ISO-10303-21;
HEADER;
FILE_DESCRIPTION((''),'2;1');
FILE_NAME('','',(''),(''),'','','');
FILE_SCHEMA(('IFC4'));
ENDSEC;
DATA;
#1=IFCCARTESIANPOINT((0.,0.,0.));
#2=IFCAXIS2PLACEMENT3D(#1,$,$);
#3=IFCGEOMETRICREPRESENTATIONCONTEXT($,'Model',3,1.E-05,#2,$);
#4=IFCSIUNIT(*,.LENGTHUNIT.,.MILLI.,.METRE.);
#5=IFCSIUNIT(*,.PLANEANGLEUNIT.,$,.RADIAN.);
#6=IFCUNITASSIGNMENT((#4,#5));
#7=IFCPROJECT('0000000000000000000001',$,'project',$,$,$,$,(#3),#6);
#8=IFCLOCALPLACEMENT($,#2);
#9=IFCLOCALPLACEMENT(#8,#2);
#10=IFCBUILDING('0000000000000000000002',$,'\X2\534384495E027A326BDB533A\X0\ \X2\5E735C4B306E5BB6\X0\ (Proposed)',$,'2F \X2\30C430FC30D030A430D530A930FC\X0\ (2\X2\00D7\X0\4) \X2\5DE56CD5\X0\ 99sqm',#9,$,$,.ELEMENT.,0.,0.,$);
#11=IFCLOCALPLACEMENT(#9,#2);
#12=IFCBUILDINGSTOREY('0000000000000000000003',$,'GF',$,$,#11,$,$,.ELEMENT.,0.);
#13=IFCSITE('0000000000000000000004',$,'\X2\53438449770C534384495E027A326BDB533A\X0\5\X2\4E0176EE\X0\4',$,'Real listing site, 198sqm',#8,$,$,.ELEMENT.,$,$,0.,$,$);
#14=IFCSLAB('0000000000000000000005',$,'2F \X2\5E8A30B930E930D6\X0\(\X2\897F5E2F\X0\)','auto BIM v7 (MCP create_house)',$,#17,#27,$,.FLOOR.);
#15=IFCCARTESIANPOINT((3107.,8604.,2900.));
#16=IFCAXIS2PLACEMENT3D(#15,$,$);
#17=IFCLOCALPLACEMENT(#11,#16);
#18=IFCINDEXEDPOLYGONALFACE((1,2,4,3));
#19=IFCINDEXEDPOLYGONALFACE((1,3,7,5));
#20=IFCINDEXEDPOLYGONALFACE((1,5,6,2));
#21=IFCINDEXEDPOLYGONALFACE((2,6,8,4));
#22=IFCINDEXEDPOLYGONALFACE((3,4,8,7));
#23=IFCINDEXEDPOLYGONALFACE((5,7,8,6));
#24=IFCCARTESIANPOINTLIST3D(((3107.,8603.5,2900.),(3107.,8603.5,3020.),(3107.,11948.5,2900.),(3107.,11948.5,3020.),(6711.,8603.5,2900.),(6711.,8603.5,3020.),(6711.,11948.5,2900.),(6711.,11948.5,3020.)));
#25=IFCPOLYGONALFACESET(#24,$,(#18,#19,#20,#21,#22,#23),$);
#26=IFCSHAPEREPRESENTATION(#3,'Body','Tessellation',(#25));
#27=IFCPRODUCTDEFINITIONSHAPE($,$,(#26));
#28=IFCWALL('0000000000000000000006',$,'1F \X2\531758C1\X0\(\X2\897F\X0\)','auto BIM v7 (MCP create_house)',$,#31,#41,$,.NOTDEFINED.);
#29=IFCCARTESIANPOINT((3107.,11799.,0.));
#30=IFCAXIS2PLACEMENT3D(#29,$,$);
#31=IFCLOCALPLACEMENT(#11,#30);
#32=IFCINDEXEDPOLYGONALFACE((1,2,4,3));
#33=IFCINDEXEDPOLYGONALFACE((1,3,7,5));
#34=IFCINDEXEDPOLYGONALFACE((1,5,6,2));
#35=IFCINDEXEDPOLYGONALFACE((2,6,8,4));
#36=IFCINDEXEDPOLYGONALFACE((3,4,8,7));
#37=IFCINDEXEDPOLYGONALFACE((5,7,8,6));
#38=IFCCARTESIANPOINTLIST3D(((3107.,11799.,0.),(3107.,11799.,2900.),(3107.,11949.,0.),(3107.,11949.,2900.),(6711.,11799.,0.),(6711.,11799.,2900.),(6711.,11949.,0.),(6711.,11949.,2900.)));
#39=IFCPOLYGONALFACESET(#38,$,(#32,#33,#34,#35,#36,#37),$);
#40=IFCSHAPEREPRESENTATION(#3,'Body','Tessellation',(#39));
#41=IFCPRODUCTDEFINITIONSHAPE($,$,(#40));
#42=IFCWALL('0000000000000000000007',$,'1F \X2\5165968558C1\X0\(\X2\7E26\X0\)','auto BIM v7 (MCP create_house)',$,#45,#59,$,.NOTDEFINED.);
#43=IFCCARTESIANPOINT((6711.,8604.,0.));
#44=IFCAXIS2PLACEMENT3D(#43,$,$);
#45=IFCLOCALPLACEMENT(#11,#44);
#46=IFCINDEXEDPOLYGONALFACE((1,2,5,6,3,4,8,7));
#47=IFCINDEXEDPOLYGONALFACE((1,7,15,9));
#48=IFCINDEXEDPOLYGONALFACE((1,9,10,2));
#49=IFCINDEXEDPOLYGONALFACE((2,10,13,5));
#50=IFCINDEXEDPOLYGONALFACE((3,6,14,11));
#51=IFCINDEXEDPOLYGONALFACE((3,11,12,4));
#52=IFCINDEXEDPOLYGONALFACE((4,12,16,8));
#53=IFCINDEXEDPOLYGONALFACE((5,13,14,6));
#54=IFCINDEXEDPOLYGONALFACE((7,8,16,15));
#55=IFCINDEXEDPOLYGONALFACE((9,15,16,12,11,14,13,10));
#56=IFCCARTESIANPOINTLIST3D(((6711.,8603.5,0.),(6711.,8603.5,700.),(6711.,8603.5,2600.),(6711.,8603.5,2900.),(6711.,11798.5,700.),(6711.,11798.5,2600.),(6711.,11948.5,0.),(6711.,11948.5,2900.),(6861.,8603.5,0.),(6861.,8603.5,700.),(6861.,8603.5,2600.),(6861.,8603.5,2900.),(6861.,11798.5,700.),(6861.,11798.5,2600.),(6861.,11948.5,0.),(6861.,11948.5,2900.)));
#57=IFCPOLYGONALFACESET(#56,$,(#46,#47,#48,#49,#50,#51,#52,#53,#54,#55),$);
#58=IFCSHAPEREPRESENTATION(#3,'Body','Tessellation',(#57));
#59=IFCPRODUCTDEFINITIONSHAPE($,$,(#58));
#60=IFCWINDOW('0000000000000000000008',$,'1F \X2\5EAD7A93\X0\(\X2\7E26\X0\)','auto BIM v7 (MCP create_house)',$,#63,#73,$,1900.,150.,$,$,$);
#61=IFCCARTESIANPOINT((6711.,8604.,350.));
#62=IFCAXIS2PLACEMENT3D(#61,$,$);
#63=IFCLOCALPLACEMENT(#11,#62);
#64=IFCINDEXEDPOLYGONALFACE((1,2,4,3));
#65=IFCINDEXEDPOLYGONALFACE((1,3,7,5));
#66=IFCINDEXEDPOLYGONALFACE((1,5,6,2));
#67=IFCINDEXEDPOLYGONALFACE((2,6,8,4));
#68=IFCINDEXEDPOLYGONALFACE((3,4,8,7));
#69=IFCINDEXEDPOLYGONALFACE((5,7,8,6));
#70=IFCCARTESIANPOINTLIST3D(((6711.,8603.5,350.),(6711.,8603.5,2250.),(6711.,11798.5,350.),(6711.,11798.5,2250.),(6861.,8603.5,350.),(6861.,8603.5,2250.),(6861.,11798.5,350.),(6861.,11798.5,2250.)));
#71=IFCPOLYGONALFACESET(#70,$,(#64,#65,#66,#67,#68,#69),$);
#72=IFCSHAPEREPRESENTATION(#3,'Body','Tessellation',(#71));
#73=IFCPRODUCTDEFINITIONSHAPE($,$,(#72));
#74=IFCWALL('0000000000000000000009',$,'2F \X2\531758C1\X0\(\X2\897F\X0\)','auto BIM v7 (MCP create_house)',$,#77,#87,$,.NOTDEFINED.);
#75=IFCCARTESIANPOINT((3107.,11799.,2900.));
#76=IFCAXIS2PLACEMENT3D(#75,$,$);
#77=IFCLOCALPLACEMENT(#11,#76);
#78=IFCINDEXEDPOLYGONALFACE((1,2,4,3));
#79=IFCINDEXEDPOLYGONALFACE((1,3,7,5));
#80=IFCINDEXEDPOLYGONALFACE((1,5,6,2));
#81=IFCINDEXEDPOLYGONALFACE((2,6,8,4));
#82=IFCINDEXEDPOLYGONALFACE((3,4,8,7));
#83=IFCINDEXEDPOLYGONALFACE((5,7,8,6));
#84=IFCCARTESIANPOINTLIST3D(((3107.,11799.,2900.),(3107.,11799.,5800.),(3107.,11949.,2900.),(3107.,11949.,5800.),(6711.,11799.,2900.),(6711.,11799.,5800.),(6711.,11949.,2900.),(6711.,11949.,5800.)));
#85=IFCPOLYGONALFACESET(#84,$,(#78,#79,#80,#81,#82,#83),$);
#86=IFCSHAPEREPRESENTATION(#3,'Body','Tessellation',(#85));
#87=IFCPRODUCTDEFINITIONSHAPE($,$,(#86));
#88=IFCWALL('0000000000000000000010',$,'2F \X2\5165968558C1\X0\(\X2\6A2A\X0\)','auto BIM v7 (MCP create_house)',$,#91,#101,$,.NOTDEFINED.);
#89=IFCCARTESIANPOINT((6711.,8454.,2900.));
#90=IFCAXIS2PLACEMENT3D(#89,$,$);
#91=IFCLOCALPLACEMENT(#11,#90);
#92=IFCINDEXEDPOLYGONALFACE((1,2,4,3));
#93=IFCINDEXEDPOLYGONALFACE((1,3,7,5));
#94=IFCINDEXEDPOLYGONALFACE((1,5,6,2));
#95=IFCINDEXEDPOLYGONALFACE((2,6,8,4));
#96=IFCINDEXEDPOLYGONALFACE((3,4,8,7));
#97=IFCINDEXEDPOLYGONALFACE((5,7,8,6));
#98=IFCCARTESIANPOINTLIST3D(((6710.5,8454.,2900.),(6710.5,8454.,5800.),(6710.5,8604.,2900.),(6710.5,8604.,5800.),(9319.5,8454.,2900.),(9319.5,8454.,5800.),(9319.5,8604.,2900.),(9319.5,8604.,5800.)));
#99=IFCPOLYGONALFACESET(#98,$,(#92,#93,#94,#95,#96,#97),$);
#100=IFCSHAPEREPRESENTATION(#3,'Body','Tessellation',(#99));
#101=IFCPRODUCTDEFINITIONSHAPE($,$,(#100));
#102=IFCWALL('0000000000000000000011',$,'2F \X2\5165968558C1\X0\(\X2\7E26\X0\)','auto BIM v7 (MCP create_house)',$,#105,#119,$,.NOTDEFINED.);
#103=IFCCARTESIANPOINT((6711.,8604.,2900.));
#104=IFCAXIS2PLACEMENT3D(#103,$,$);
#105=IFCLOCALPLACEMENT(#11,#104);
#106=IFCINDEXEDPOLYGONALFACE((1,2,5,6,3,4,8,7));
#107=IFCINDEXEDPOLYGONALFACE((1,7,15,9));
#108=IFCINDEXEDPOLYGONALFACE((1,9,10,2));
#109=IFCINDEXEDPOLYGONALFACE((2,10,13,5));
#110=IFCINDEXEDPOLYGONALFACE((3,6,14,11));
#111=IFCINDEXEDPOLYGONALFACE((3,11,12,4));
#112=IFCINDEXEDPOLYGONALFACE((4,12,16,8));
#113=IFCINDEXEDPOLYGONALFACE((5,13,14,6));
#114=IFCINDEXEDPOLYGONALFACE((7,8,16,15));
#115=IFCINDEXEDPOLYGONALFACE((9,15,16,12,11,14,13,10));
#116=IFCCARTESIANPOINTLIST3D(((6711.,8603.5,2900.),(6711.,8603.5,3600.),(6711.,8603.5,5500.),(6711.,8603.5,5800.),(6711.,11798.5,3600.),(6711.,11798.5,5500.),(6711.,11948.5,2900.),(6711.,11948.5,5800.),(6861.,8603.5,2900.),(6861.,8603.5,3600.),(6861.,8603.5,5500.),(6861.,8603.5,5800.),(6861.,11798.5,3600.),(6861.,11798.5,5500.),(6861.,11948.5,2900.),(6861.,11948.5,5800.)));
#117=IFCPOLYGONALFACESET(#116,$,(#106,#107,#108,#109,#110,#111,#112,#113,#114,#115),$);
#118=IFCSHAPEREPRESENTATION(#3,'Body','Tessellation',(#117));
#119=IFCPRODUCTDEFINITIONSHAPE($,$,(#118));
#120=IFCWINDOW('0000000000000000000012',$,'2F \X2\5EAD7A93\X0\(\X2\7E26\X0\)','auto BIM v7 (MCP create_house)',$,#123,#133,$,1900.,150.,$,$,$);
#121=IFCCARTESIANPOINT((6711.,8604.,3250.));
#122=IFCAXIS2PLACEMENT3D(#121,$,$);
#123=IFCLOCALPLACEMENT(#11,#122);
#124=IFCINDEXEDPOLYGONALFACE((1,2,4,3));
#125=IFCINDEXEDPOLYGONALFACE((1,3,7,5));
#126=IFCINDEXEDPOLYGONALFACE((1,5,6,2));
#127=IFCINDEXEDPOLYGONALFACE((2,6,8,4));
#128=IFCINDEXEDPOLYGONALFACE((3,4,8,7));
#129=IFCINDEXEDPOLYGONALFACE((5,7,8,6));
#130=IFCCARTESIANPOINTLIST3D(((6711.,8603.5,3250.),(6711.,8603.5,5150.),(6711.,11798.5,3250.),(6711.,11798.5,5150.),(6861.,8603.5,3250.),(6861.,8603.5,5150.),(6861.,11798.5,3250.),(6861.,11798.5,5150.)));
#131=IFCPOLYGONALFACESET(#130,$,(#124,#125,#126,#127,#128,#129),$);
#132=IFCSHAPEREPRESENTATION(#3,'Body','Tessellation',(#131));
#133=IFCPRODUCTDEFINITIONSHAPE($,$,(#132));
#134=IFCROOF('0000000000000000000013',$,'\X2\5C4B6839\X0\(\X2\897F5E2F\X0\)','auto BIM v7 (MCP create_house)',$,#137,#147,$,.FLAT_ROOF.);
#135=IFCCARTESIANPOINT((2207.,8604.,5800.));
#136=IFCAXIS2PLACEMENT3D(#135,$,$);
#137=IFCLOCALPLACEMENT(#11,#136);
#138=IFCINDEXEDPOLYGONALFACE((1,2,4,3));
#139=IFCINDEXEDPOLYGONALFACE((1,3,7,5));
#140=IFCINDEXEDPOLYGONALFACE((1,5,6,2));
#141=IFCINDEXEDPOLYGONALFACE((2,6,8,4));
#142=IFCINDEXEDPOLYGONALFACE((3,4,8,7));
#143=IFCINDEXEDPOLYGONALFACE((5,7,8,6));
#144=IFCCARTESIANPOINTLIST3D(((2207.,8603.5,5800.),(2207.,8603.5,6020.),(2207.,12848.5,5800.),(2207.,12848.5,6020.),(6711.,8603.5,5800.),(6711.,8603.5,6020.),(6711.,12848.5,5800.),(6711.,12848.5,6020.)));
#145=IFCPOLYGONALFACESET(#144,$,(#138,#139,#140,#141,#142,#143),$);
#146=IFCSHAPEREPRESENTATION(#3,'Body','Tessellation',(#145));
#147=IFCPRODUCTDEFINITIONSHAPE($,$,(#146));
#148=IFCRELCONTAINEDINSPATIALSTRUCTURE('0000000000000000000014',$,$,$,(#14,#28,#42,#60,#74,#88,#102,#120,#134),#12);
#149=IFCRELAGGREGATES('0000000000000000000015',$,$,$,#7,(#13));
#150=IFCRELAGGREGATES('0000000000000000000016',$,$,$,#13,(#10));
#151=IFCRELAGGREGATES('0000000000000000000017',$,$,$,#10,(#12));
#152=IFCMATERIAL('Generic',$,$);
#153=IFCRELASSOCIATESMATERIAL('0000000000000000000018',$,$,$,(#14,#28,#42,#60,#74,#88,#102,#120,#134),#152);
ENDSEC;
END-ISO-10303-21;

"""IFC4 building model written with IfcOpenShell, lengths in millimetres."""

from ifc_helpers import new_model, si_unit, frame, frame_2d, origin, place, context, project, spatial, rectangle, extrude, material, element, fill, save


model = new_model("IFC4")

# Units and contexts
model_context = context("Model", 3, precision=1e-05, world=origin())
ifc_project = project(units=[si_unit("LENGTHUNIT", "METRE", prefix="MILLI"), si_unit("PLANEANGLEUNIT", "RADIAN")], contexts=[model_context])

# Site, building, storey
site_placement = place(None, origin())
site = spatial("IfcSite", under=ifc_project, at=site_placement, Name="千葉県千葉市稲毛区5丁目4", ObjectType="Real listing site, 198sqm", CompositionType="ELEMENT", RefElevation=0.0)
building_placement = place(site_placement, origin())
building = spatial("IfcBuilding", under=site, at=building_placement, Name="千葉市稲毛区 平屋の家 (Proposed)", ObjectType="2F ツーバイフォー (2×4) 工法 99sqm", CompositionType="ELEMENT", ElevationOfRefHeight=0.0, ElevationOfTerrain=0.0)
storey_placement = place(building_placement, origin())
storey = spatial("IfcBuildingStorey", under=building, at=storey_placement, Name="GF", CompositionType="ELEMENT", Elevation=0.0)

# Slab
ifc_material = material(Name="Generic")
slab_1_placement = place(storey_placement, frame((3107.0, 8604.0, 2900.0)))
element("IfcSlab", 1, at=slab_1_placement, inside=storey, material=ifc_material, Name="2F 床スラブ(西帯)", Description="auto BIM v7 (MCP create_house)", PredefinedType="FLOOR", context=model_context, shape_type="SweptSolid", body=[
    extrude(rectangle(XDim=3604.0, YDim=3345.0, at=frame_2d((1802.0, 1672.0))), frame((3107.0, 8604.0, 2900.0)), (0.0, 0.0, 1.0), 120.0),
])

# Wall
wall_1_placement = place(storey_placement, frame((3107.0, 11799.0, 0.0)))
element("IfcWall", 2, at=wall_1_placement, inside=storey, material=ifc_material, Name="1F 北壁(西)", Description="auto BIM v7 (MCP create_house)", PredefinedType="NOTDEFINED", context=model_context, shape_type="SweptSolid", body=[
    extrude(rectangle(XDim=3604.0, YDim=150.0, at=frame_2d((1802.0, 75.0))), frame((3107.0, 11799.0, 0.0)), (0.0, 0.0, 1.0), 2900.0),
])

# Wall, opening, window
wall_2_placement = place(storey_placement, frame((6711.0, 8604.0, 0.0)))
wall_2 = element("IfcWall", 3, at=wall_2_placement, inside=storey, material=ifc_material, Name="1F 入隅壁(縦)", Description="auto BIM v7 (MCP create_house)", PredefinedType="NOTDEFINED", context=model_context, shape_type="SweptSolid", body=[
    extrude(rectangle(XDim=150.0, YDim=3345.0, at=frame_2d((75.0, 1672.0))), frame((6711.0, 8604.0, 0.0)), (0.0, 0.0, 1.0), 2900.0),
])
opening_1_placement = place(storey_placement, frame((6711.0, 8604.0, 350.0)))
opening_1 = element("IfcOpeningElement", 4, at=opening_1_placement, cuts=wall_2, PredefinedType="NOTDEFINED", context=model_context, shape_type="SweptSolid", body=[
    extrude(rectangle(XDim=150.0, YDim=3195.0, at=frame_2d((75.0, 1597.0))), frame((6711.0, 8604.0, 350.0)), (0.0, 0.0, 1.0), 1900.0),
])
window_1_placement = place(storey_placement, frame((6711.0, 8604.0, 350.0)))
window_1 = element("IfcWindow", 5, at=window_1_placement, inside=storey, material=ifc_material, Name="1F 庭窓(縦)", Description="auto BIM v7 (MCP create_house)", OverallHeight=1900.0, OverallWidth=150.0, context=model_context, shape_type="SweptSolid", body=[
    extrude(rectangle(XDim=150.0, YDim=3195.0, at=frame_2d((75.0, 1597.0))), frame((6711.0, 8604.0, 350.0)), (0.0, 0.0, 1.0), 1900.0),
])
fill(opening_1, window_1)

# Walls
wall_3_placement = place(storey_placement, frame((3107.0, 11799.0, 2900.0)))
element("IfcWall", 6, at=wall_3_placement, inside=storey, material=ifc_material, Name="2F 北壁(西)", Description="auto BIM v7 (MCP create_house)", PredefinedType="NOTDEFINED", context=model_context, shape_type="SweptSolid", body=[
    extrude(rectangle(XDim=3604.0, YDim=150.0, at=frame_2d((1802.0, 75.0))), frame((3107.0, 11799.0, 2900.0)), (0.0, 0.0, 1.0), 2900.0),
])
wall_4_placement = place(storey_placement, frame((6711.0, 8454.0, 2900.0)))
element("IfcWall", 7, at=wall_4_placement, inside=storey, material=ifc_material, Name="2F 入隅壁(横)", Description="auto BIM v7 (MCP create_house)", PredefinedType="NOTDEFINED", context=model_context, shape_type="SweptSolid", body=[
    extrude(rectangle(XDim=2609.0, YDim=150.0, at=frame_2d((1304.0, 75.0))), frame((6711.0, 8454.0, 2900.0)), (0.0, 0.0, 1.0), 2900.0),
])

# Wall, opening, window
wall_5_placement = place(storey_placement, frame((6711.0, 8604.0, 2900.0)))
wall_5 = element("IfcWall", 8, at=wall_5_placement, inside=storey, material=ifc_material, Name="2F 入隅壁(縦)", Description="auto BIM v7 (MCP create_house)", PredefinedType="NOTDEFINED", context=model_context, shape_type="SweptSolid", body=[
    extrude(rectangle(XDim=150.0, YDim=3345.0, at=frame_2d((75.0, 1672.0))), frame((6711.0, 8604.0, 2900.0)), (0.0, 0.0, 1.0), 2900.0),
])
opening_2_placement = place(storey_placement, frame((6711.0, 8604.0, 3250.0)))
opening_2 = element("IfcOpeningElement", 9, at=opening_2_placement, cuts=wall_5, PredefinedType="NOTDEFINED", context=model_context, shape_type="SweptSolid", body=[
    extrude(rectangle(XDim=150.0, YDim=3195.0, at=frame_2d((75.0, 1597.0))), frame((6711.0, 8604.0, 3250.0)), (0.0, 0.0, 1.0), 1900.0),
])
window_2_placement = place(storey_placement, frame((6711.0, 8604.0, 3250.0)))
window_2 = element("IfcWindow", 10, at=window_2_placement, inside=storey, material=ifc_material, Name="2F 庭窓(縦)", Description="auto BIM v7 (MCP create_house)", OverallHeight=1900.0, OverallWidth=150.0, context=model_context, shape_type="SweptSolid", body=[
    extrude(rectangle(XDim=150.0, YDim=3195.0, at=frame_2d((75.0, 1597.0))), frame((6711.0, 8604.0, 3250.0)), (0.0, 0.0, 1.0), 1900.0),
])
fill(opening_2, window_2)

# Roof
for number, where, name in (
    (11, (2207.0, 8604.0, 5800.0), "屋根(西帯)"),
):
    element("IfcRoof", number, at=place(storey_placement, frame(where)), inside=storey, material=ifc_material, Name=name, Description="auto BIM v7 (MCP create_house)", PredefinedType="FLAT_ROOF", context=model_context, shape_type="SweptSolid", body=[
        extrude(rectangle(XDim=4504.0, YDim=4245.0, at=frame_2d((2252.0, 2122.0))), frame((2207.0, 8604.0, 5800.0)), (0.0, 0.0, 1.0), 220.0),
    ])

save(model, "model.ifc")
